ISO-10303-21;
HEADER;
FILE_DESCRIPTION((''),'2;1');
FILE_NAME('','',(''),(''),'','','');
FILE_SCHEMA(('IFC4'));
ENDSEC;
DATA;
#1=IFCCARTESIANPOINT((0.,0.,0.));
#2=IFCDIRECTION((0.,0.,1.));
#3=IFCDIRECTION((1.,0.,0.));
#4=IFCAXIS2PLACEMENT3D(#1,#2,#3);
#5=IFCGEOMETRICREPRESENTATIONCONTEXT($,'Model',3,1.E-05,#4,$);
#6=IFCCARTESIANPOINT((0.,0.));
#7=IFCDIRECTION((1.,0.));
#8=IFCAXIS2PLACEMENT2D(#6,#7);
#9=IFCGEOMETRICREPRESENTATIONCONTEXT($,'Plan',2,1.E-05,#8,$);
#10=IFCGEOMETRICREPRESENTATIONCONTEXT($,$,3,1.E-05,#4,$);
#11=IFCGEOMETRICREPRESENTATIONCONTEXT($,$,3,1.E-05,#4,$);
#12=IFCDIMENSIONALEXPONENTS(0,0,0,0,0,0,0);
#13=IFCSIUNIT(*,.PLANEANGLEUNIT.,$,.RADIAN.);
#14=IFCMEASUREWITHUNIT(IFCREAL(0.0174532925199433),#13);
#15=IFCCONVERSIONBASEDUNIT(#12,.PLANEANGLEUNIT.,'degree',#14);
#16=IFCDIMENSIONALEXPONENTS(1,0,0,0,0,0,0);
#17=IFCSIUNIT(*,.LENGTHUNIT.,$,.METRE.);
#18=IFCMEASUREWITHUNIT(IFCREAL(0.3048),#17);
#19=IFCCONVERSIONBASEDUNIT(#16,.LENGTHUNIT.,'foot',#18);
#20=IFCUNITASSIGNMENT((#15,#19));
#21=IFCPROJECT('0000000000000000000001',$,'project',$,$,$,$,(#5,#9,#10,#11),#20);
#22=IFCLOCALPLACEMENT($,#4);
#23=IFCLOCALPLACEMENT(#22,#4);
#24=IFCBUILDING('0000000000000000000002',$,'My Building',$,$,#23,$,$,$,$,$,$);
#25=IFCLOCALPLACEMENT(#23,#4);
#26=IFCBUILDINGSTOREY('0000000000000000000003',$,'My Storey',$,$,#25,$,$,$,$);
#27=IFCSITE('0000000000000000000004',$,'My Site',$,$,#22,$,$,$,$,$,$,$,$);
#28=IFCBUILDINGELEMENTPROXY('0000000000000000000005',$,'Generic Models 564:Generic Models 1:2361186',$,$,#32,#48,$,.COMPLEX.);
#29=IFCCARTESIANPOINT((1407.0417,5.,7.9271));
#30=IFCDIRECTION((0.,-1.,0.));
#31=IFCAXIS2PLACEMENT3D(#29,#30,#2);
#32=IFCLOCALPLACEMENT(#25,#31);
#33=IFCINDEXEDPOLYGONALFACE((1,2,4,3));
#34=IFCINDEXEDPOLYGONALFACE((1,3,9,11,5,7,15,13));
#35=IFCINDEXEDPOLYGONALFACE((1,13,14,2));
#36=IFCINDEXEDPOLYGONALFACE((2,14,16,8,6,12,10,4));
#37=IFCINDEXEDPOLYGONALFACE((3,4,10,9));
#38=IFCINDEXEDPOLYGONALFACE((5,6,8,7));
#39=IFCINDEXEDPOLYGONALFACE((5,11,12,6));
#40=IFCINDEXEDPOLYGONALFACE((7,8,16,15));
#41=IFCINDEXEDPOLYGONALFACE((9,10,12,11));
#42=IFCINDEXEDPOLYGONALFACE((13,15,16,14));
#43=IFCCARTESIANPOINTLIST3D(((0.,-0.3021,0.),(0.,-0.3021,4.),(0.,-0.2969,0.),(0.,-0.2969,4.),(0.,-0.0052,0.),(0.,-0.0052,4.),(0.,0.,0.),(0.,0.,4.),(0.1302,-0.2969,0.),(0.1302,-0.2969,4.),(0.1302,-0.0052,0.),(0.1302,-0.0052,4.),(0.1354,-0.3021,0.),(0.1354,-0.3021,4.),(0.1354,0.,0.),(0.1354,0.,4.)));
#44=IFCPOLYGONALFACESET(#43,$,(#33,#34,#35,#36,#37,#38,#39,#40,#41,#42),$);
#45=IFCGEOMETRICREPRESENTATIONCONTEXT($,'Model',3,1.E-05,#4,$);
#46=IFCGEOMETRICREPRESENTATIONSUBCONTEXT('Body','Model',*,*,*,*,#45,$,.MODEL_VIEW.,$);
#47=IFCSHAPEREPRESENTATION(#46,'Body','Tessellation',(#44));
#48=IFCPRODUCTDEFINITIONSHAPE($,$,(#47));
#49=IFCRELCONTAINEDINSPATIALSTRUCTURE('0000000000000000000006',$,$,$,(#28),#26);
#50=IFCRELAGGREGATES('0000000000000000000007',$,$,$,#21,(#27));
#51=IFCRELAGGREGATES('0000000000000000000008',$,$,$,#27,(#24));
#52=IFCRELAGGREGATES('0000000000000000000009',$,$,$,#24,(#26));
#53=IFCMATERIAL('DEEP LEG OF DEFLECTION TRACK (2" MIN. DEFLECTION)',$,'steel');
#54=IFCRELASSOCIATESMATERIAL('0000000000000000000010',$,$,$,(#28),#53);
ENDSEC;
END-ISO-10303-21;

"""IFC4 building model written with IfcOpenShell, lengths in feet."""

from ifc_helpers import new_model, entity, si_unit, converted_unit, frame, origin_with_axes, origin_2d_with_axis, place, context, subcontext, project, spatial, polyline, outline, extrude, material, element, save


model = new_model("IFC4")

# Units and contexts
model_context_1 = context("Model", 3, precision=1e-05, world=origin_with_axes())
plan_context = context("Plan", 2, precision=1e-05, world=origin_2d_with_axis())
model_context_2 = context("Model", 3, precision=1e-05, world=origin_with_axes())
context_of_model_1 = context(None, 3, precision=1e-05, world=origin_with_axes())
context_of_model_2 = context(None, 3, precision=1e-05, world=origin_with_axes())
body_context = subcontext(model_context_2, "Body", "Model", "MODEL_VIEW")
ifc_project = project(units=[converted_unit("PLANEANGLEUNIT", "degree", entity("IfcReal", 0.0174532925199433), si_unit("PLANEANGLEUNIT", "RADIAN"), dimensions=[0, 0, 0, 0, 0, 0, 0]), converted_unit("LENGTHUNIT", "foot", entity("IfcReal", 0.3048), si_unit("LENGTHUNIT", "METRE"), dimensions=[1, 0, 0, 0, 0, 0, 0])], contexts=[model_context_1, plan_context, context_of_model_1, context_of_model_2])

# Site, building, storey
site_placement = place(None, origin_with_axes())
site = spatial("IfcSite", under=ifc_project, at=site_placement, Name="My Site")
building_placement = place(site_placement, origin_with_axes())
building = spatial("IfcBuilding", under=site, at=building_placement, Name="My Building")
storey_placement = place(building_placement, origin_with_axes())
storey = spatial("IfcBuildingStorey", under=building, at=storey_placement, Name="My Storey")

# Building element proxy
ifc_material_1 = material(Name="DEEP LEG OF DEFLECTION TRACK (2\" MIN. DEFLECTION)", Category="steel")
proxy_1_placement = place(storey_placement, frame((1407.0417, 5.0, 7.9271), z_axis=(0.0, -1.0, 0.0), x_axis=(0.0, 0.0, 1.0)))
element("IfcBuildingElementProxy", 1, at=proxy_1_placement, inside=storey, material=ifc_material_1, Name="Generic Models 564:Generic Models 1:2361186", PredefinedType="COMPLEX", context=body_context, shape_type="SweptSolid", body=[
    extrude(outline(polyline([(-0.069, -0.151), (0.0664, -0.151), (0.0664, -0.1458), (-0.0638, -0.1458), (-0.0638, 0.1458), (0.0664, 0.1458), (0.0664, 0.151), (-0.069, 0.151), (-0.069, -0.151)])), frame((0.0664, -0.151, 0.0), z_axis=(0.0, 0.0, -1.0), x_axis=(-1.0, 0.0, 0.0)), (0.0, 0.0, -1.0), 4.0),
])

save(model, "model.ifc")
